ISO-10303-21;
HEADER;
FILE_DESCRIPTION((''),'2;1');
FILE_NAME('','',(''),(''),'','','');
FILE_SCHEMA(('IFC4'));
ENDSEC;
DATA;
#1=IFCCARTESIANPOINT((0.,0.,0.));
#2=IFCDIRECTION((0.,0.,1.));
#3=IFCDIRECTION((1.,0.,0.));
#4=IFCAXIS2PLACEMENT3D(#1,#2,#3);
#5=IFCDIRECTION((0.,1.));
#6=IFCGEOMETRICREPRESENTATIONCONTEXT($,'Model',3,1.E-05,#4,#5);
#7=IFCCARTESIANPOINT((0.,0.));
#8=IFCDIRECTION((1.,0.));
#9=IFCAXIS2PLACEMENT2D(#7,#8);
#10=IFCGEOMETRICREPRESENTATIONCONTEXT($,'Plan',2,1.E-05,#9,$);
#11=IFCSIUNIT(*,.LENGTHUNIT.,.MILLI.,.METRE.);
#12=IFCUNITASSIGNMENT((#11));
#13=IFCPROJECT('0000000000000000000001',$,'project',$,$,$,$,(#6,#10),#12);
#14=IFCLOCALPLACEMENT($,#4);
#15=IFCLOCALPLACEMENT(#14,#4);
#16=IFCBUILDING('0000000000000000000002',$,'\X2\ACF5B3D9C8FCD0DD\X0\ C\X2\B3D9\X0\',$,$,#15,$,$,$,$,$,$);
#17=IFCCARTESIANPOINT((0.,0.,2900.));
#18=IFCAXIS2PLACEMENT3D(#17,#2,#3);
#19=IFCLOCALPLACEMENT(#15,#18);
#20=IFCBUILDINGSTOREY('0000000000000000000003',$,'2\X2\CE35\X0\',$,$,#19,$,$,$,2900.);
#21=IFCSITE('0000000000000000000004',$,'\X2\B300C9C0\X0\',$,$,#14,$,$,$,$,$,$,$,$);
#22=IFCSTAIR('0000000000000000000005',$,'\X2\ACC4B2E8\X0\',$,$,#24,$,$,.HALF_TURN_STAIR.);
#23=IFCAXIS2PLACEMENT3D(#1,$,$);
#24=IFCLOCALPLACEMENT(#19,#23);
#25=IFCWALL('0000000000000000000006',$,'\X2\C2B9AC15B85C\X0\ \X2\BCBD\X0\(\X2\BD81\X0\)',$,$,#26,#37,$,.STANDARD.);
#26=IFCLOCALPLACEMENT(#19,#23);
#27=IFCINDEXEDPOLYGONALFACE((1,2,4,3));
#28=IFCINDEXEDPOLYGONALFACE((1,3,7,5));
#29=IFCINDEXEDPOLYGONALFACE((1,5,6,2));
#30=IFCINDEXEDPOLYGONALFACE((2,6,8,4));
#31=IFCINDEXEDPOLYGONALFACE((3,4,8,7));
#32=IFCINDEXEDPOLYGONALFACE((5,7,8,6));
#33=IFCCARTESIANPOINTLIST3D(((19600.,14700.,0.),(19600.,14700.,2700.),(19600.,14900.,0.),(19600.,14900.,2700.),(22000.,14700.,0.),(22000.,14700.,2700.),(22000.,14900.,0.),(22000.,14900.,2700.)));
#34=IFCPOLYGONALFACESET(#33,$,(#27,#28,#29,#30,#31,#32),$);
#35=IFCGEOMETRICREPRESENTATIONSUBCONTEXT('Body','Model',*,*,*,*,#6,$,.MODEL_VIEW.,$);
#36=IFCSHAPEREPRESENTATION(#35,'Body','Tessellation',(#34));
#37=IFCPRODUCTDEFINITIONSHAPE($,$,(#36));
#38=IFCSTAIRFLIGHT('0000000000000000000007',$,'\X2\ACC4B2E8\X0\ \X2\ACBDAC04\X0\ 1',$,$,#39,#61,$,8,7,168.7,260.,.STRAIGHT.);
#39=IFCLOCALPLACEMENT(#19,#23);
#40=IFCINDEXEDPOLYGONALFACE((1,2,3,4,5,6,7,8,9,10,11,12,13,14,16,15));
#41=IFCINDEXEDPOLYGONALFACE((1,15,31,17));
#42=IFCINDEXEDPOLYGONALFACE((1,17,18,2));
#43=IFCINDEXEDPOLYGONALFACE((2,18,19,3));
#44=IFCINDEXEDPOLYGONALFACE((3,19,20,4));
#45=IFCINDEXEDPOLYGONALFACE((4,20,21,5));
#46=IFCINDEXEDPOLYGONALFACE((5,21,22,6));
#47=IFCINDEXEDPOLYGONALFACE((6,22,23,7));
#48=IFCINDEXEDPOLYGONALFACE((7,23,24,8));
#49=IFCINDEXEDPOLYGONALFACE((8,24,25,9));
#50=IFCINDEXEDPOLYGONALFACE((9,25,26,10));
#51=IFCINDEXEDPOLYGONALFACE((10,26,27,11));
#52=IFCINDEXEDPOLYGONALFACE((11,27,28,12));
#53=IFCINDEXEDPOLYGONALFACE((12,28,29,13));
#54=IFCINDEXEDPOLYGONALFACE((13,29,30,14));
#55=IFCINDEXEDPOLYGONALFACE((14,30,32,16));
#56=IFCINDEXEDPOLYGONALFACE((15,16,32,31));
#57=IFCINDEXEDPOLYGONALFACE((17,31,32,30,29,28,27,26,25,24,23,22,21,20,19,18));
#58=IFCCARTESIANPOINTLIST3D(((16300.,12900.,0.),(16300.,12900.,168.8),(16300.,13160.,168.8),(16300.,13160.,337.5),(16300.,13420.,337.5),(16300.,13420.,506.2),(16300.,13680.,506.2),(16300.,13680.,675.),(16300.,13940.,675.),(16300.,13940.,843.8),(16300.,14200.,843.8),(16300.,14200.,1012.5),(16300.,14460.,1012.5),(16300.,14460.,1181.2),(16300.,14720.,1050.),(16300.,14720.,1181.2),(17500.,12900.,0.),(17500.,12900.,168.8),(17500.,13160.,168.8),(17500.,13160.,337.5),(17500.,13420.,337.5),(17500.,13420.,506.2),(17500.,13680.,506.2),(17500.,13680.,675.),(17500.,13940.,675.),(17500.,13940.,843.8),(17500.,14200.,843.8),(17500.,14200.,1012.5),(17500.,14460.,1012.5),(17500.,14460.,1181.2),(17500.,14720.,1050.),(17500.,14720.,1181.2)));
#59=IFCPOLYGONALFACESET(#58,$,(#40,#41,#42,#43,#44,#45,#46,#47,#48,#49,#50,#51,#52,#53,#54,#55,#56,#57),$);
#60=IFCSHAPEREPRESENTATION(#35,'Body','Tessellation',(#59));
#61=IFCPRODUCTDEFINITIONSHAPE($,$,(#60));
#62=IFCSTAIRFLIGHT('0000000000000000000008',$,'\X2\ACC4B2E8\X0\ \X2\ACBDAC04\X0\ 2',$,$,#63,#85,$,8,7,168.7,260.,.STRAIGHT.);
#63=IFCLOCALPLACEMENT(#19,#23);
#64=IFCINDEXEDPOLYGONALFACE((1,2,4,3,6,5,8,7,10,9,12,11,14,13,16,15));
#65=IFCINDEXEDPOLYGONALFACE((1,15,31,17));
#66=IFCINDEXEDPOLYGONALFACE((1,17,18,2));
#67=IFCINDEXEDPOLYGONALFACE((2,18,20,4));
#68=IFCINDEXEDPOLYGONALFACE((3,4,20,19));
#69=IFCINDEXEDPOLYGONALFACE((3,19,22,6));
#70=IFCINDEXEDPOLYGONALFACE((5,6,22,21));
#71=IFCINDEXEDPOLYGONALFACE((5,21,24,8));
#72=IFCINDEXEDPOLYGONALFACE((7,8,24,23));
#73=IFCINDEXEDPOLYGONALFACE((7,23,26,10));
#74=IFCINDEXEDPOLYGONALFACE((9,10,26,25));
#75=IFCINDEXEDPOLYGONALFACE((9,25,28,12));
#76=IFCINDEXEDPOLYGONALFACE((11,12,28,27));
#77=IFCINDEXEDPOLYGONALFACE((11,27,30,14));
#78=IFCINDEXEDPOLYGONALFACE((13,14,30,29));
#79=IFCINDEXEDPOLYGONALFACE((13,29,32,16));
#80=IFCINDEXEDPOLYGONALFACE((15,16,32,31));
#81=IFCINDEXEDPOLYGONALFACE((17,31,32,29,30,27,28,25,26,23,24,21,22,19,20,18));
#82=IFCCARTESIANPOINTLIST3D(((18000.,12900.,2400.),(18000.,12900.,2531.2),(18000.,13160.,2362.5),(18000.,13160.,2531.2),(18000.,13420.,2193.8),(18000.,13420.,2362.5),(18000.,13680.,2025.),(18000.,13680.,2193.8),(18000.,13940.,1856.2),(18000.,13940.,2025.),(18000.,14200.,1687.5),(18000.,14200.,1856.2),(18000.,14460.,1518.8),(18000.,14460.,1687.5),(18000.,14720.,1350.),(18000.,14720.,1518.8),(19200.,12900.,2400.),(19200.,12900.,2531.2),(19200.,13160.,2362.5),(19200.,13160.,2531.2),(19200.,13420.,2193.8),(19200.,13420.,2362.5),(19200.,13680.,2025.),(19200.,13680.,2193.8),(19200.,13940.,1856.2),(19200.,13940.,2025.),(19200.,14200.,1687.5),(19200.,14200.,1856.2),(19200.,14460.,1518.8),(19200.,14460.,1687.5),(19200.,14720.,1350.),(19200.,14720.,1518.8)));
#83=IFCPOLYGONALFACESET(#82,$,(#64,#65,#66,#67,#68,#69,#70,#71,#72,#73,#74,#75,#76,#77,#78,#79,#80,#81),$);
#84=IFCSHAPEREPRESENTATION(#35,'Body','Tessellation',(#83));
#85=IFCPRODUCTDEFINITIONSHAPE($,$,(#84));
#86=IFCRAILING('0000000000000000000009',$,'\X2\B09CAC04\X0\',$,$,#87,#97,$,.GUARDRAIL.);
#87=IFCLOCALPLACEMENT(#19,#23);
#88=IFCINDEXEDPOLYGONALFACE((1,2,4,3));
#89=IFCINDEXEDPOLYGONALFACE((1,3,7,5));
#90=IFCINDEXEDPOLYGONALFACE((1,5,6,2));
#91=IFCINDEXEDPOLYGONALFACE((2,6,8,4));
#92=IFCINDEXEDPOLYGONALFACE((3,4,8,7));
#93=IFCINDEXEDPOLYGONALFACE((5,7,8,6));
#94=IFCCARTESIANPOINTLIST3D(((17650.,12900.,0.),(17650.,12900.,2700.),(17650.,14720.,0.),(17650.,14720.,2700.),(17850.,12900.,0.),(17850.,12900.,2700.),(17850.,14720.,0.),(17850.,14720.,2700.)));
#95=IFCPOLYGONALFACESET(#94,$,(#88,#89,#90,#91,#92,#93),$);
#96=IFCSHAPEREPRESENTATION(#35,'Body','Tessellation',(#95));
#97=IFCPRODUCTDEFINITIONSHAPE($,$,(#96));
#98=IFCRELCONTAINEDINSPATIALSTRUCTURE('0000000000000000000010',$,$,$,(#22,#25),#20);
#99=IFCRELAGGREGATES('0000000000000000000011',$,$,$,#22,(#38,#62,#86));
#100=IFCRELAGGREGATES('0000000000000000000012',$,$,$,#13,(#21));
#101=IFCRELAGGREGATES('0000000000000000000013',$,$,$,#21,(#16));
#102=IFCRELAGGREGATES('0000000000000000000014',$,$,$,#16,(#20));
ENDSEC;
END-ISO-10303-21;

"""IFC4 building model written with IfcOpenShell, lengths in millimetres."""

from ifc_helpers import new_model, si_unit, direction, frame, origin_with_axes, origin_2d_with_axis, place, context, subcontext, project, spatial, polyline, outline, extrude, element, aggregate, save


model = new_model("IFC4")

# Units and contexts
model_context = context("Model", 3, precision=1e-05, world=origin_with_axes(), true_north=direction((0.0, 1.0)))
plan_context = context("Plan", 2, precision=1e-05, world=origin_2d_with_axis())
body_context = subcontext(model_context, "Body", "Model", "MODEL_VIEW")
ifc_project = project(units=[si_unit("LENGTHUNIT", "METRE", prefix="MILLI")], contexts=[model_context, plan_context])

# Site, building, storey
site_placement = place(None, origin_with_axes())
site = spatial("IfcSite", under=ifc_project, at=site_placement, Name="대지")
building_placement = place(site_placement, origin_with_axes())
building = spatial("IfcBuilding", under=site, at=building_placement, Name="공동주택 C동")
storey_placement = place(building_placement, frame((0.0, 0.0, 2900.0), z_axis=(0.0, 0.0, 1.0), x_axis=(1.0, 0.0, 0.0)))
storey = spatial("IfcBuildingStorey", under=building, at=storey_placement, Name="2층", Elevation=2900.0)

# Stair
stair_placement = place(storey_placement, origin_with_axes())
stair = element("IfcStair", 1, at=stair_placement, inside=storey, Name="계단", PredefinedType="HALF_TURN_STAIR")

# Wall
wall_1_placement = place(storey_placement, origin_with_axes())
element("IfcWall", 2, at=wall_1_placement, inside=storey, Name="승강로 벽(북)", PredefinedType="STANDARD", context=body_context, shape_type="SweptSolid", body=[
    extrude(outline(polyline([(19600.0, 14900.0), (22000.0, 14900.0), (22000.0, 14700.0), (19600.0, 14700.0), (19600.0, 14900.0)])), origin_with_axes(), (0.0, 0.0, 1.0), 2700.0),
])

# Stair flights
stair_flight_1_placement = place(stair_placement, origin_with_axes())
stair_flight_1 = element("IfcStairFlight", 3, at=stair_flight_1_placement, Name="계단 경간 1", NumberOfRisers=8, NumberOfTreads=7, PredefinedType="STRAIGHT", RiserHeight=168.7, TreadLength=260.0, context=body_context, shape_type="SweptSolid", body=[
    extrude(outline(polyline([(0.0, 0.0), (0.0, 168.7), (260.0, 168.7), (260.0, 337.5), (520.0, 337.5), (520.0, 506.2), (780.0, 506.2), (780.0, 675.0), (1040.0, 675.0), (1040.0, 843.7), (1300.0, 843.7), (1300.0, 1012.5), (1560.0, 1012.5), (1560.0, 1181.2), (1820.0, 1181.2), (1820.0, 1350.0), (1820.0, 1050.0), (0.0, 0.0)])), frame((16300.0, 12900.0, 0.0), z_axis=(1.0, 0.0, 0.0), x_axis=(0.0, 1.0, 0.0)), (0.0, 0.0, 1.0), 1200.0),
])
stair_flight_2_placement = place(stair_placement, origin_with_axes())
stair_flight_2 = element("IfcStairFlight", 4, at=stair_flight_2_placement, Name="계단 경간 2", NumberOfRisers=8, NumberOfTreads=7, PredefinedType="STRAIGHT", RiserHeight=168.7, TreadLength=260.0, context=body_context, shape_type="SweptSolid", body=[
    extrude(outline(polyline([(0.0, 0.0), (0.0, 168.7), (260.0, 168.7), (260.0, 337.5), (520.0, 337.5), (520.0, 506.2), (780.0, 506.2), (780.0, 675.0), (1040.0, 675.0), (1040.0, 843.7), (1300.0, 843.7), (1300.0, 1012.5), (1560.0, 1012.5), (1560.0, 1181.2), (1820.0, 1181.2), (1820.0, 1350.0), (1820.0, 1050.0), (0.0, 0.0)])), frame((19200.0, 14720.0, 1350.0), z_axis=(-1.0, 0.0, 0.0), x_axis=(0.0, -1.0, 0.0)), (0.0, 0.0, 1.0), 1200.0),
])

# Railing
railing_placement = place(stair_placement, origin_with_axes())
railing = element("IfcRailing", 5, at=railing_placement, Name="난간", PredefinedType="GUARDRAIL", context=body_context, shape_type="SweptSolid", body=[
    extrude(outline(polyline([(17650.0, 12900.0), (17850.0, 12900.0), (17850.0, 14720.0), (17650.0, 14720.0), (17650.0, 12900.0)])), origin_with_axes(), (0.0, 0.0, 1.0), 2700.0),
])
aggregate(stair, [stair_flight_1, stair_flight_2, railing])

save(model, "model.ifc")
